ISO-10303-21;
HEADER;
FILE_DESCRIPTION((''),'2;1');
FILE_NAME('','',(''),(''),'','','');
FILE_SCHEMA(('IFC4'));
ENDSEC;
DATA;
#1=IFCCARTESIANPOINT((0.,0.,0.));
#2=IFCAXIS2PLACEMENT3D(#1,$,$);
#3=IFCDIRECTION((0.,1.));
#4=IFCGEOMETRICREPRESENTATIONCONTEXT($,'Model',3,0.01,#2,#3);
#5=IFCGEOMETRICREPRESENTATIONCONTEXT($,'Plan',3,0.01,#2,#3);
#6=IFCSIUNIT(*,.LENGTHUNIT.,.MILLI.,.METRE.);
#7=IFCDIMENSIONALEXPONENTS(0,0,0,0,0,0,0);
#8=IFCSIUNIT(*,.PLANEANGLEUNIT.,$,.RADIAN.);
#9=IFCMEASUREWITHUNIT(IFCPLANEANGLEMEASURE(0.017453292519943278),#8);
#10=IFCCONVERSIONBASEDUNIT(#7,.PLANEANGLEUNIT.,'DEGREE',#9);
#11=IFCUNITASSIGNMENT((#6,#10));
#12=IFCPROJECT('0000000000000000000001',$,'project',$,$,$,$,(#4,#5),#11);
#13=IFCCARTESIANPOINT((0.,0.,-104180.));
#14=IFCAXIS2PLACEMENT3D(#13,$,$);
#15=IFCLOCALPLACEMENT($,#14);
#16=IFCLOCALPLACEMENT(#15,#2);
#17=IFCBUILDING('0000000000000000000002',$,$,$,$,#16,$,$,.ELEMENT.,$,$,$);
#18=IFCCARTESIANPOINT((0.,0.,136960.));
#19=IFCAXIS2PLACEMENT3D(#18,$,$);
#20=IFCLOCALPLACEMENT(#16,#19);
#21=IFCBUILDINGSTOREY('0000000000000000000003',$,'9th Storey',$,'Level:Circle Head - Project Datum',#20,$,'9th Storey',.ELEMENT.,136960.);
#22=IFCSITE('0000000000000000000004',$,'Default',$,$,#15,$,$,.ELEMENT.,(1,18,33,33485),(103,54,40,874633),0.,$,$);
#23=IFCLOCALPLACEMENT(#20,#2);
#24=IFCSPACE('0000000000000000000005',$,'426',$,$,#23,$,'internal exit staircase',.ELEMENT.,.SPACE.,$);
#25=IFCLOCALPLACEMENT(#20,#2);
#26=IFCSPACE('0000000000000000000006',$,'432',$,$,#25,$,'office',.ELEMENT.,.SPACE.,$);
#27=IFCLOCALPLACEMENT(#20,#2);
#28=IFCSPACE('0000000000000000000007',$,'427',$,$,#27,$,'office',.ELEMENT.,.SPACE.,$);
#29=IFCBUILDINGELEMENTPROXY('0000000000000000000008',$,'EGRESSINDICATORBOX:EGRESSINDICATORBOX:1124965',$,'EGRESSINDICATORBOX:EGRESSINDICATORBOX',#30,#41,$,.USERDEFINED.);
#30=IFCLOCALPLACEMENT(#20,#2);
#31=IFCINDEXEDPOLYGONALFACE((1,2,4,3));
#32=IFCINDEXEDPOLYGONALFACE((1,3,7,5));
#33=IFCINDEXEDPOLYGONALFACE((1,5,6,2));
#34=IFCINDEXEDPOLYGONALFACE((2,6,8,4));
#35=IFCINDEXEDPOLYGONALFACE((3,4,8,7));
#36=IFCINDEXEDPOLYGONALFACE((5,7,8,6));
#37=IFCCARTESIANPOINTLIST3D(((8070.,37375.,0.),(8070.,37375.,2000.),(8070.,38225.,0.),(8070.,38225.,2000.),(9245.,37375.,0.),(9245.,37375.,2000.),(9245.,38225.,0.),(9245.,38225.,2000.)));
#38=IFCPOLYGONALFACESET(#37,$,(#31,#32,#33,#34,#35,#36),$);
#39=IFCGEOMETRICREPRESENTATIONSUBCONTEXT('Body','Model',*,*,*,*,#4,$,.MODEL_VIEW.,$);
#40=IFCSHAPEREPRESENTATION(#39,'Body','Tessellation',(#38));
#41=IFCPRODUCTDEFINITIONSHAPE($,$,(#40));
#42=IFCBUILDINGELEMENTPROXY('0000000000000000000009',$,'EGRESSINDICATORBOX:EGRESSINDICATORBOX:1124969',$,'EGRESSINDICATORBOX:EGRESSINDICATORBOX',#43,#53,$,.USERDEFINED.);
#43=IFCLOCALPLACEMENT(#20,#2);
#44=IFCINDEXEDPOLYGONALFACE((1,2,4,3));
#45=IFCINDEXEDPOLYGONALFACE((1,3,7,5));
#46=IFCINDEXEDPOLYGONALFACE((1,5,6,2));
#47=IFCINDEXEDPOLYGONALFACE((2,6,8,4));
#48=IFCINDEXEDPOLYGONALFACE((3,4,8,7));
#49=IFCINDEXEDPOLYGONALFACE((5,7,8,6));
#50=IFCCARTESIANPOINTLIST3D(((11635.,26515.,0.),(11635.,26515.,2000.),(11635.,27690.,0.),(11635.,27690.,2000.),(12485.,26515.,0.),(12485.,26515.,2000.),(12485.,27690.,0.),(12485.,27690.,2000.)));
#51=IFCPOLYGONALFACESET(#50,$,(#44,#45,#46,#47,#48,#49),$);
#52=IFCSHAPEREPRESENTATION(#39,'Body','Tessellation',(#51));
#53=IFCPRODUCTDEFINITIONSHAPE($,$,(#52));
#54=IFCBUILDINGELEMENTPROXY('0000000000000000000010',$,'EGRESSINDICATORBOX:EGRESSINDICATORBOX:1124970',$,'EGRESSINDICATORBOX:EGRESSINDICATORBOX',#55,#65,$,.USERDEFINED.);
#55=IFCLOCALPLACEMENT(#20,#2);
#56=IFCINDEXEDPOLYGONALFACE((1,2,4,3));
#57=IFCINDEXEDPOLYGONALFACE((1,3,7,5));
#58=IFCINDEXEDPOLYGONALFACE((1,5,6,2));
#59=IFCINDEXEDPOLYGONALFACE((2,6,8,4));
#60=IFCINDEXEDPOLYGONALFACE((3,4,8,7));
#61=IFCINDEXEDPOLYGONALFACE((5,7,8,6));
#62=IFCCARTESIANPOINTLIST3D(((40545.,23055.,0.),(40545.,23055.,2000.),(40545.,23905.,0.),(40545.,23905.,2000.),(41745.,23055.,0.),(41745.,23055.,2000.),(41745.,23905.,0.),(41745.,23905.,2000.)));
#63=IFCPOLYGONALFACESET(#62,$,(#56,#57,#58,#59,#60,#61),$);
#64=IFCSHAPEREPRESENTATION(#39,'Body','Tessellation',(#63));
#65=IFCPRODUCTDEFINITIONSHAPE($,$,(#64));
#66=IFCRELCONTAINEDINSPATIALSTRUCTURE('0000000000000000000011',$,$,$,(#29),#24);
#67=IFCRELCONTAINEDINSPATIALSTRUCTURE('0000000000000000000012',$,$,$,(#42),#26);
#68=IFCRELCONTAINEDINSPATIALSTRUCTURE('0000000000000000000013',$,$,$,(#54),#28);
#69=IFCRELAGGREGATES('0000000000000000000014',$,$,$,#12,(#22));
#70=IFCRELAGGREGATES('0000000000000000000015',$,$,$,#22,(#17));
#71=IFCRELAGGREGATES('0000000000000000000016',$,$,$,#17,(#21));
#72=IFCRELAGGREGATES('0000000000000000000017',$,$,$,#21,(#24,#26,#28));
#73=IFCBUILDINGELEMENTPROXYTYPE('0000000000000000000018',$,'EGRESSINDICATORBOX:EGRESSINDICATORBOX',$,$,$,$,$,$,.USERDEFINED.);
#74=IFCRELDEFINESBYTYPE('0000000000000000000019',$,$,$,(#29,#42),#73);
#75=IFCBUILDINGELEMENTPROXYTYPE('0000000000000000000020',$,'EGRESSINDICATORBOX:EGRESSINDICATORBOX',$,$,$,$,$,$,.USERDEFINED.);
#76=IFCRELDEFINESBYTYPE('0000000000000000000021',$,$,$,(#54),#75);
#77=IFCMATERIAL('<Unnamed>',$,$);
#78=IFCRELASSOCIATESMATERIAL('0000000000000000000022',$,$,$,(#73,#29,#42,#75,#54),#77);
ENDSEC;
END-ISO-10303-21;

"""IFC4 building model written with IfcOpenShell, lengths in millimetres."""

from ifc_helpers import new_model, entity, si_unit, converted_unit, direction, frame, origin, place, context, subcontext, project, spatial, indexed_curve, outline, extrude, source, transform, mapped, material, type_object, type_shapes, element, save


model = new_model("IFC4")

# Units and contexts
model_context = context("Model", 3, precision=0.01, world=origin(), true_north=direction((0.0, 1.0)))
plan_context = context("Plan", 3, precision=0.01, world=origin(), true_north=direction((0.0, 1.0)))
body_context = subcontext(model_context, "Body", "Model", "MODEL_VIEW")
ifc_project = project(units=[si_unit("LENGTHUNIT", "METRE", prefix="MILLI"), converted_unit("PLANEANGLEUNIT", "DEGREE", entity("IfcPlaneAngleMeasure", 0.017453292519943278), si_unit("PLANEANGLEUNIT", "RADIAN"), dimensions=[0, 0, 0, 0, 0, 0, 0])], contexts=[model_context, plan_context])

# Site, building, storey
site_placement = place(None, frame((0.0, 0.0, -104180.0)))
site = spatial("IfcSite", under=ifc_project, at=site_placement, Name="Default", CompositionType="ELEMENT", RefLatitude=(1, 18, 33, 33485), RefLongitude=(103, 54, 40, 874633), RefElevation=0.0)
building_placement = place(site_placement, origin())
building = spatial("IfcBuilding", under=site, at=building_placement, CompositionType="ELEMENT")
storey_placement = place(building_placement, frame((0.0, 0.0, 136960.0)))
storey = spatial("IfcBuildingStorey", under=building, at=storey_placement, Name="9th Storey", ObjectType="Level:Circle Head - Project Datum", LongName="9th Storey", CompositionType="ELEMENT", Elevation=136960.0)

# Shared definitions
ifc_material_1 = material(Name="<Unnamed>")

# Shared definitions
building_element_proxy_type_1 = type_object("IfcBuildingElementProxyType", Name="EGRESSINDICATORBOX:EGRESSINDICATORBOX", PredefinedType="USERDEFINED", material=ifc_material_1)
shared_shape_1 = source(origin(), body_context, "Body", "SweptSolid", [
    extrude(outline(indexed_curve([(-425.0, -587.5), (425.0, -587.5), (425.0, 587.5), (-425.0, 587.5), (-425.0, -587.5)], self_intersect=False)), frame((0.0, 0.0, 0.0), z_axis=(0.0, 0.0, 1.0), x_axis=(-1.0, 0.0, 0.0)), (0.0, 0.0, 1.0), 2000.0),
])
type_shapes(building_element_proxy_type_1, [shared_shape_1])

# Shared definitions
space_1_placement = place(storey_placement, origin())
space_1 = spatial("IfcSpace", under=storey, at=space_1_placement, Name="426", LongName="internal exit staircase", CompositionType="ELEMENT", PredefinedType="SPACE")

# Building element proxy
proxy_1_placement = place(space_1_placement, frame((8657.5, 37800.0, 0.0), z_axis=(0.0, 0.0, 1.0), x_axis=(0.0, 1.0, 0.0)))
element("IfcBuildingElementProxy", 1, at=proxy_1_placement, inside=space_1, type_object=building_element_proxy_type_1, material=ifc_material_1, Name="EGRESSINDICATORBOX:EGRESSINDICATORBOX:1124965", ObjectType="EGRESSINDICATORBOX:EGRESSINDICATORBOX", PredefinedType="USERDEFINED", context=body_context, shape_type="MappedRepresentation", body=[
    mapped(shared_shape_1, transform((0.0, 0.0, 0.0), scale=1.0)),
])

# Shared definitions
space_2_placement = place(storey_placement, origin())
space_2 = spatial("IfcSpace", under=storey, at=space_2_placement, Name="432", LongName="office", CompositionType="ELEMENT", PredefinedType="SPACE")

# Building element proxy
proxy_2_placement = place(space_2_placement, frame((12060.0, 27102.5, 0.0)))
element("IfcBuildingElementProxy", 2, at=proxy_2_placement, inside=space_2, type_object=building_element_proxy_type_1, material=ifc_material_1, Name="EGRESSINDICATORBOX:EGRESSINDICATORBOX:1124969", ObjectType="EGRESSINDICATORBOX:EGRESSINDICATORBOX", PredefinedType="USERDEFINED", context=body_context, shape_type="MappedRepresentation", body=[
    mapped(shared_shape_1, transform((0.0, 0.0, 0.0), scale=1.0)),
])

# Shared definitions
space_3_placement = place(storey_placement, origin())
space_3 = spatial("IfcSpace", under=storey, at=space_3_placement, Name="427", LongName="office", CompositionType="ELEMENT", PredefinedType="SPACE")

# Building element proxy
building_element_proxy_type_2 = type_object("IfcBuildingElementProxyType", Name="EGRESSINDICATORBOX:EGRESSINDICATORBOX", PredefinedType="USERDEFINED", material=ifc_material_1)
shared_shape_2 = source(origin(), body_context, "Body", "SweptSolid", [
    extrude(outline(indexed_curve([(-600.0, -425.0), (600.0, -425.0), (600.0, 425.0), (-600.0, 425.0), (-600.0, -425.0)], self_intersect=False)), frame((0.0, 0.0, 0.0), z_axis=(0.0, 0.0, 1.0), x_axis=(0.0, 1.0, 0.0)), (0.0, 0.0, 1.0), 2000.0),
])
type_shapes(building_element_proxy_type_2, [shared_shape_2])
proxy_3_placement = place(space_3_placement, frame((41145.0, 23480.0, 0.0), z_axis=(0.0, 0.0, 1.0), x_axis=(0.0, -1.0, 0.0)))
element("IfcBuildingElementProxy", 3, at=proxy_3_placement, inside=space_3, type_object=building_element_proxy_type_2, material=ifc_material_1, Name="EGRESSINDICATORBOX:EGRESSINDICATORBOX:1124970", ObjectType="EGRESSINDICATORBOX:EGRESSINDICATORBOX", PredefinedType="USERDEFINED", context=body_context, shape_type="MappedRepresentation", body=[
    mapped(shared_shape_2, transform((0.0, 0.0, 0.0), scale=1.0)),
])

save(model, "model.ifc")
